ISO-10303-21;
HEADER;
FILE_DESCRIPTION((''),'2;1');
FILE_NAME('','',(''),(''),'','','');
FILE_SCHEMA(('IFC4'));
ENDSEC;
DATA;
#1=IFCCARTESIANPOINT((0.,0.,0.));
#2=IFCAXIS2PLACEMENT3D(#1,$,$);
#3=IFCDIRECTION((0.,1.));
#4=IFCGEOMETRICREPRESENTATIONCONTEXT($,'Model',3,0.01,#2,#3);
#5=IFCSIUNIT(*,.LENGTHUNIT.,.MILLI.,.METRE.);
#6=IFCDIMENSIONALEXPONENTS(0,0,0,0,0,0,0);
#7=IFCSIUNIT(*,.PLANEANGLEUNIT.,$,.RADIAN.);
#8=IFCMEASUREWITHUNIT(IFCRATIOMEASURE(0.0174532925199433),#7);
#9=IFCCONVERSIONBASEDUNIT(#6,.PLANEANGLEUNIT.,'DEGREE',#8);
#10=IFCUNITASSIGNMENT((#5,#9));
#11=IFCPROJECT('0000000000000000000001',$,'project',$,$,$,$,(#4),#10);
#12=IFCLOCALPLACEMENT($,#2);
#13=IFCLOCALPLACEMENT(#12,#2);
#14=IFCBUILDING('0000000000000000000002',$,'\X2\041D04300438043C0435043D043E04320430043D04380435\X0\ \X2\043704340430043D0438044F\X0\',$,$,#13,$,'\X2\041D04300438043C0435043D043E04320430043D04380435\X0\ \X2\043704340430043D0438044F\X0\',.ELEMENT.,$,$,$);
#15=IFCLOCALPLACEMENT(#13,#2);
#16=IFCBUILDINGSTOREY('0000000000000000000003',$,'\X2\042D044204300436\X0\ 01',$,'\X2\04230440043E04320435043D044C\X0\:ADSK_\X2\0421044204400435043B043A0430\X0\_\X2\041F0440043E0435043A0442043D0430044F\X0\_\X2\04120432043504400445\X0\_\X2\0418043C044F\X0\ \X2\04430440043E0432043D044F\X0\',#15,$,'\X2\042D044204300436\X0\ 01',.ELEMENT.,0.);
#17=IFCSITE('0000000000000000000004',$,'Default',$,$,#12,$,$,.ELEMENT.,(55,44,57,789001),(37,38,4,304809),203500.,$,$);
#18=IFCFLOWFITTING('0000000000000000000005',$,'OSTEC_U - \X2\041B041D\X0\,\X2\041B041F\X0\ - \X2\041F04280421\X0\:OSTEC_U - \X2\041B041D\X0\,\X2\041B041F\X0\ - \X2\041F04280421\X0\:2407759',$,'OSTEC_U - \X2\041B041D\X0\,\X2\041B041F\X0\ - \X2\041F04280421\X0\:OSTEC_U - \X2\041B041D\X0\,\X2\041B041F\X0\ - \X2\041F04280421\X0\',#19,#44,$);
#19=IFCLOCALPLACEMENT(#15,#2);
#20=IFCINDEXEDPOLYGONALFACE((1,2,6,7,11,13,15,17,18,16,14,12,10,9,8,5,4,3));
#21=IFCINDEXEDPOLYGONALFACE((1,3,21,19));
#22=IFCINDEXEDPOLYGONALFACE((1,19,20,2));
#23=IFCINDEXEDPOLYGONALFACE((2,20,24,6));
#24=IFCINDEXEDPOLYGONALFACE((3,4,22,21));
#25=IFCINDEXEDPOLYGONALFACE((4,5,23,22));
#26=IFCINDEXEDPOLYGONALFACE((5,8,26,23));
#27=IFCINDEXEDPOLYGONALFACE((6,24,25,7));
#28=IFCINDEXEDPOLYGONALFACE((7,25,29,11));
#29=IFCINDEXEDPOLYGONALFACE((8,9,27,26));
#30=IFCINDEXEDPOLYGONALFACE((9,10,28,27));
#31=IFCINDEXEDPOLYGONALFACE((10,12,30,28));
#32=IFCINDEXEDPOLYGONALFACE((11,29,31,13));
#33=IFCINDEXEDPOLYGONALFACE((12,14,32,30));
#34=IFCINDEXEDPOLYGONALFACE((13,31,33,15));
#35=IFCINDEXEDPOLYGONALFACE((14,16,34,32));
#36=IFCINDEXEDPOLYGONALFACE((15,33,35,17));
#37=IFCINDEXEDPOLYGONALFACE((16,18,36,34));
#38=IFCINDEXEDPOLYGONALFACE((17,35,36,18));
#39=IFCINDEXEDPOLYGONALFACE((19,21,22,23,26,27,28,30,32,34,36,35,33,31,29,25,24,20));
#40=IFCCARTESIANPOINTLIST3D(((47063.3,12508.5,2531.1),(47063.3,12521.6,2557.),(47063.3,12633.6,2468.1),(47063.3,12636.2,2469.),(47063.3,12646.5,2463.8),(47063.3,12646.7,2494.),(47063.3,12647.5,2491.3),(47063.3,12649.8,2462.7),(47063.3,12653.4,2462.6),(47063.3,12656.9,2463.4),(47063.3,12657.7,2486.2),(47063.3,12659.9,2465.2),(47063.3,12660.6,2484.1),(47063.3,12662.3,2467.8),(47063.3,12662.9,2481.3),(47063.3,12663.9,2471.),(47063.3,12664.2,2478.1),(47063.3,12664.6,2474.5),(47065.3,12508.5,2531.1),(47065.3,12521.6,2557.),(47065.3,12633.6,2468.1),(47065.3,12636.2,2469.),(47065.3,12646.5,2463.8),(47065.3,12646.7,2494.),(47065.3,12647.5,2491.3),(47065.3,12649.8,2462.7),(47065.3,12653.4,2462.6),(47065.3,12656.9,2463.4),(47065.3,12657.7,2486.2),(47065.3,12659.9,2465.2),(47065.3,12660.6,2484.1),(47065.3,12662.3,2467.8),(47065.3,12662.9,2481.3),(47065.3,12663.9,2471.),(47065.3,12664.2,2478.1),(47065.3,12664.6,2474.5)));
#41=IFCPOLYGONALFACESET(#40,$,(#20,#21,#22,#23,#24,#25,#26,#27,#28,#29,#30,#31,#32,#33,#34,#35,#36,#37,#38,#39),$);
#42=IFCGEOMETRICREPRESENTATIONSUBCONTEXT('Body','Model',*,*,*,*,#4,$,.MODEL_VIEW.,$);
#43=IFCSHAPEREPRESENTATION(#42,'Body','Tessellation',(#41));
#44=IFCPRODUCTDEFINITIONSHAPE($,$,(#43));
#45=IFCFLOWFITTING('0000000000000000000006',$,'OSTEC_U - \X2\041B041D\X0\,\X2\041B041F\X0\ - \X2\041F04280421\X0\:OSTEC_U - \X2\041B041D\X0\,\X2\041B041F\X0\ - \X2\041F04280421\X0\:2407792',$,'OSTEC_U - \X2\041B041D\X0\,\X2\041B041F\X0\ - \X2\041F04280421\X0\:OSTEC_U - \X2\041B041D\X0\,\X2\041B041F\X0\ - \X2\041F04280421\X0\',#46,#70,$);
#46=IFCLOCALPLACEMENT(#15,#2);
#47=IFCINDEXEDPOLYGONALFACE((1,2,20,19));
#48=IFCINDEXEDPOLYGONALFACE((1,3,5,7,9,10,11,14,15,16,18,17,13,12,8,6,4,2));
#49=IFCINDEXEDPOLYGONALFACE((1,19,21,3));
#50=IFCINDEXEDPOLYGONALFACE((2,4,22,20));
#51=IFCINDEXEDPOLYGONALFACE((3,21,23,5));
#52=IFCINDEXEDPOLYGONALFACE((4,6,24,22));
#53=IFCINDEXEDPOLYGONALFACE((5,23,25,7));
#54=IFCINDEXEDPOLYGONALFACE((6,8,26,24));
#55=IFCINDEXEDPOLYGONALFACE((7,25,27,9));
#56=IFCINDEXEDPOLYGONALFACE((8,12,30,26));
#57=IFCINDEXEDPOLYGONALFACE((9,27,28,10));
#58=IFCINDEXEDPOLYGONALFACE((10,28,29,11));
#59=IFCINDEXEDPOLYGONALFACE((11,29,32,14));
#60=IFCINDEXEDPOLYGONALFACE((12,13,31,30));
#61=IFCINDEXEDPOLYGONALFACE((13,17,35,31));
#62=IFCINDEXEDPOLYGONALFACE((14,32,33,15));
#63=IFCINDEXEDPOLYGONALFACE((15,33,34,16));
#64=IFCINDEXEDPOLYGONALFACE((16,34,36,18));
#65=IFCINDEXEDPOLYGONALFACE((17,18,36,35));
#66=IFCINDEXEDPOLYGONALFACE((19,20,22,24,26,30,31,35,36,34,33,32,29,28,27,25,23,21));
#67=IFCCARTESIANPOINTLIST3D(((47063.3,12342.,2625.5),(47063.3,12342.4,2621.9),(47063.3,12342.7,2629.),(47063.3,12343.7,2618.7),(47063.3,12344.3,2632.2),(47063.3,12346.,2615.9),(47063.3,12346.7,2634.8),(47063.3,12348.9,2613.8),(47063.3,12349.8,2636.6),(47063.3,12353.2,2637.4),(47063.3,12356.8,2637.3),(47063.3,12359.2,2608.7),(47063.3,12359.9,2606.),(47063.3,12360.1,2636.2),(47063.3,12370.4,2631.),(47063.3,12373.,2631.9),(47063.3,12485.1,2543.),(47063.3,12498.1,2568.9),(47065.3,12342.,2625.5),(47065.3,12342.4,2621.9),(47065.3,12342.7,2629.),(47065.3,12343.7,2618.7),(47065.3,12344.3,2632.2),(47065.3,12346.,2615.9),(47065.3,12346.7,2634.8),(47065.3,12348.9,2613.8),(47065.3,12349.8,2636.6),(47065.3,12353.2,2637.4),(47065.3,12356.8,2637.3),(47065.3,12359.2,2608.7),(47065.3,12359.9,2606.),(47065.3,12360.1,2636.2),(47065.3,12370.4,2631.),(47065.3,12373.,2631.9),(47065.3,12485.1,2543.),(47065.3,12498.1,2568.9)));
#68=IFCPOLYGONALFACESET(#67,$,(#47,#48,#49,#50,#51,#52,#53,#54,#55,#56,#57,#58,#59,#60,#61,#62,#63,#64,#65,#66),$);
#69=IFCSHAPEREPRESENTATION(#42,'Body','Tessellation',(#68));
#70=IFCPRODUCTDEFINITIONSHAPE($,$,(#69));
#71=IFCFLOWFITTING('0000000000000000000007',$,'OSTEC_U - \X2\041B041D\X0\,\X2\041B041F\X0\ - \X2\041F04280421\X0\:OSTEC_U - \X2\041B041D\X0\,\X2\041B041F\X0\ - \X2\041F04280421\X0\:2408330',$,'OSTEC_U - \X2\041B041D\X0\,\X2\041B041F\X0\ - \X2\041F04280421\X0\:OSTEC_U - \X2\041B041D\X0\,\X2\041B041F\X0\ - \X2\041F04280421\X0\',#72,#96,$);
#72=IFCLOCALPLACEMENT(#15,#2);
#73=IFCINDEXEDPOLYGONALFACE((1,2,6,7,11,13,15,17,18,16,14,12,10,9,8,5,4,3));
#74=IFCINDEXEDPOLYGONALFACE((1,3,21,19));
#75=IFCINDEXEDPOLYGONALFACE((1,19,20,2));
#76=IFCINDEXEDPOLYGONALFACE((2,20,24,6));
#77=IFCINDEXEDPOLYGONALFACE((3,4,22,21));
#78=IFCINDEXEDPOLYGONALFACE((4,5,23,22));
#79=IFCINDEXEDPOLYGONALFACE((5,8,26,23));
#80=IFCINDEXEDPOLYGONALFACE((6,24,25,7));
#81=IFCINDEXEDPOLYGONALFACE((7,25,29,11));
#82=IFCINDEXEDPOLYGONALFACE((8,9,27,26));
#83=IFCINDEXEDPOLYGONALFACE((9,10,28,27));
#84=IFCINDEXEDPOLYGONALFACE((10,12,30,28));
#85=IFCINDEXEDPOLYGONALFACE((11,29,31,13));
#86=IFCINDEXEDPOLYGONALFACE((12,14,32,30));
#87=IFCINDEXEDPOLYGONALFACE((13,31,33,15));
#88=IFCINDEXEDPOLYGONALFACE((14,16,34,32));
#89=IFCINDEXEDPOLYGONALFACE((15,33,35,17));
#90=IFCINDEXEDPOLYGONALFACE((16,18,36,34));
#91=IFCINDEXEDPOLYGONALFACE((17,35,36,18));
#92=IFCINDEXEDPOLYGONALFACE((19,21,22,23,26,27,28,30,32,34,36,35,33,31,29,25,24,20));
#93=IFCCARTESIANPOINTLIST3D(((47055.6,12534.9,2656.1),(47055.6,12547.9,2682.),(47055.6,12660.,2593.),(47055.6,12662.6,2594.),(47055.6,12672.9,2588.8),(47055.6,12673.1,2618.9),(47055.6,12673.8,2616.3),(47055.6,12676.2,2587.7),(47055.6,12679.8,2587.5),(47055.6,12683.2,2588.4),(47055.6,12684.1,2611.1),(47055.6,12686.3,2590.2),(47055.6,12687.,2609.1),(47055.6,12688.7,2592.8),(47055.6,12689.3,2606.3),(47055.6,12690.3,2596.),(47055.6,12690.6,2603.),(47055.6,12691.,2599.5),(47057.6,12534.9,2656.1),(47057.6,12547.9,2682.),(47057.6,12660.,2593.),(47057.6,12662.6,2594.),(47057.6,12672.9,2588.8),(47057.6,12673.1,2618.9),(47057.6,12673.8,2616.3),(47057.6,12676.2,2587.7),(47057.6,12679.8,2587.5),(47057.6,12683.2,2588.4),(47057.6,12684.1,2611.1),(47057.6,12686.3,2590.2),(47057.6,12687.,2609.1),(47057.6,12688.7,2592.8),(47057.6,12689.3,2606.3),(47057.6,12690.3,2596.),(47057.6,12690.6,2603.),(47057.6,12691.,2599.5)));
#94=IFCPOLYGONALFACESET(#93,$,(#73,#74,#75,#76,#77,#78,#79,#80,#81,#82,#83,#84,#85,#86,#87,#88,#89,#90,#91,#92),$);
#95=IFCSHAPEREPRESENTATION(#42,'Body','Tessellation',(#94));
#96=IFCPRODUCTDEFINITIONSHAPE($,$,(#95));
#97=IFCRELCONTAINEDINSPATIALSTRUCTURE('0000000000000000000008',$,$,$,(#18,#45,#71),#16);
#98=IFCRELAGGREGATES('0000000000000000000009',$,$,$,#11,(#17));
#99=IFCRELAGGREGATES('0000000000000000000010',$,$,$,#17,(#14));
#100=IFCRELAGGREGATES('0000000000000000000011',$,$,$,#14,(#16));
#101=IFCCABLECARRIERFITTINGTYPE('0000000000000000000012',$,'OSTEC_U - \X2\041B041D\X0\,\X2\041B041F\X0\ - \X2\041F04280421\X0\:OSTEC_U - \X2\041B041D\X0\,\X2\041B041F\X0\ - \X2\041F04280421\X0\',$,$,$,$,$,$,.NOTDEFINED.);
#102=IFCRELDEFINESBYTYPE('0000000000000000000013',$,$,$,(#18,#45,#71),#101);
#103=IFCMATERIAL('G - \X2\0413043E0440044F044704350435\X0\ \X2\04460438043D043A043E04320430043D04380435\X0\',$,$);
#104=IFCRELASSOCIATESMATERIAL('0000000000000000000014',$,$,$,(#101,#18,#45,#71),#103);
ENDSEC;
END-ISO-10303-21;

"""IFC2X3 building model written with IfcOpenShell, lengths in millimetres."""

from ifc_helpers import new_model, entity, si_unit, converted_unit, direction, frame, frame_2d, origin, place, context, subcontext, project, spatial, polyline, circle_curve, parameter, trimmed, segment, composite_curve, outline, extrude, source, transform, mapped, material, type_object, type_shapes, element, save


model = new_model("IFC2X3")

# Units and contexts
model_context = context("Model", 3, precision=0.01, world=origin(), true_north=direction((0.0, 1.0)))
body_context = subcontext(model_context, "Body", "Model", "MODEL_VIEW")
ifc_project = project(units=[si_unit("LENGTHUNIT", "METRE", prefix="MILLI"), converted_unit("PLANEANGLEUNIT", "DEGREE", entity("IfcRatioMeasure", 0.0174532925199433), si_unit("PLANEANGLEUNIT", "RADIAN"), dimensions=[0, 0, 0, 0, 0, 0, 0])], contexts=[model_context])

# Site, building, storey
site_placement = place(None, origin())
site = spatial("IfcSite", under=ifc_project, at=site_placement, Name="Default", CompositionType="ELEMENT", RefLatitude=(55, 44, 57, 789001), RefLongitude=(37, 38, 4, 304809), RefElevation=203500.0)
building_placement = place(site_placement, origin())
building = spatial("IfcBuilding", under=site, at=building_placement, Name="Наименование здания", LongName="Наименование здания", CompositionType="ELEMENT")
storey_placement = place(building_placement, origin())
storey = spatial("IfcBuildingStorey", under=building, at=storey_placement, Name="Этаж 01", ObjectType="Уровень:ADSK_Стрелка_Проектная_Вверх_Имя уровня", LongName="Этаж 01", CompositionType="ELEMENT", Elevation=0.0)

# Flow fittings
ifc_material_1 = material(Name="G - Горячее цинкование")
shared_shape_1 = source(origin(), body_context, "Body", "SweptSolid", [
    extrude(outline(composite_curve([segment(trimmed(circle_curve(frame_2d((-44.6, 0.0), x_axis=(1.0, 0.0)), 12.5), [parameter(90.0)], [parameter(270.0)], True, "PARAMETER"), True, "CONTINUOUS"), segment(polyline([(-44.6, -12.5), (-33.1, -12.5)]), True, "CONTINUOUS"), segment(polyline([(-33.1, -12.5), (-31.2, -14.5)]), True, "CONTINUOUS"), segment(polyline([(-31.2, -14.5), (108.9, -14.5)]), True, "CONTINUOUS"), segment(polyline([(108.9, -14.5), (108.9, 14.5)]), True, "CONTINUOUS"), segment(polyline([(108.9, 14.5), (-31.2, 14.5)]), True, "CONTINUOUS"), segment(polyline([(-31.2, 14.5), (-33.1, 12.5)]), True, "CONTINUOUS"), segment(polyline([(-33.1, 12.5), (-44.6, 12.5)]), True, "CONTINUOUS")], self_intersect=False)), frame((44.6, 0.0, 0.0)), (0.0, 0.0, 1.0), 2.0),
])
cable_carrier_fitting_type_1 = type_object("IfcCableCarrierFittingType", Name="OSTEC_U - ЛН,ЛП - ПШС:OSTEC_U - ЛН,ЛП - ПШС", PredefinedType="NOTDEFINED", material=ifc_material_1)
type_shapes(cable_carrier_fitting_type_1, [shared_shape_1])
flow_fitting_1_placement = place(storey_placement, frame((47063.3, 12652.1, 2475.0), z_axis=(1.0, 0.0, 0.0), x_axis=(0.0, -0.892981, 0.450095)))
element("IfcFlowFitting", 1, at=flow_fitting_1_placement, inside=storey, type_object=cable_carrier_fitting_type_1, material=ifc_material_1, Name="OSTEC_U - ЛН,ЛП - ПШС:OSTEC_U - ЛН,ЛП - ПШС:2407759", ObjectType="OSTEC_U - ЛН,ЛП - ПШС:OSTEC_U - ЛН,ЛП - ПШС", context=body_context, shape_type="MappedRepresentation", body=[
    mapped(shared_shape_1, transform((0.0, 0.0, 0.0), scale=1.0)),
])
flow_fitting_2_placement = place(storey_placement, frame((47063.3, 12354.5, 2625.0), z_axis=(1.0, 0.0, 0.0), x_axis=(0.0, 0.892981, -0.450095)))
element("IfcFlowFitting", 2, at=flow_fitting_2_placement, inside=storey, type_object=cable_carrier_fitting_type_1, material=ifc_material_1, Name="OSTEC_U - ЛН,ЛП - ПШС:OSTEC_U - ЛН,ЛП - ПШС:2407792", ObjectType="OSTEC_U - ЛН,ЛП - ПШС:OSTEC_U - ЛН,ЛП - ПШС", context=body_context, shape_type="MappedRepresentation", body=[
    mapped(shared_shape_1, transform((0.0, 0.0, 0.0), scale=1.0)),
])
for number, where, z_axis, x_axis, name in (
    (3, (47055.6, 12678.5, 2599.9), (1.0, 0.0, 0.0), (0.0, -0.892981, 0.450095), "OSTEC_U - ЛН,ЛП - ПШС:OSTEC_U - ЛН,ЛП - ПШС:2408330"),
):
    element("IfcFlowFitting", number, at=place(storey_placement, frame(where, z_axis=z_axis, x_axis=x_axis)), inside=storey, type_object=cable_carrier_fitting_type_1, material=ifc_material_1, Name=name, ObjectType="OSTEC_U - ЛН,ЛП - ПШС:OSTEC_U - ЛН,ЛП - ПШС", context=body_context, shape_type="MappedRepresentation", body=[
        mapped(shared_shape_1, transform((0.0, 0.0, 0.0), scale=1.0)),
    ])

save(model, "model.ifc")
